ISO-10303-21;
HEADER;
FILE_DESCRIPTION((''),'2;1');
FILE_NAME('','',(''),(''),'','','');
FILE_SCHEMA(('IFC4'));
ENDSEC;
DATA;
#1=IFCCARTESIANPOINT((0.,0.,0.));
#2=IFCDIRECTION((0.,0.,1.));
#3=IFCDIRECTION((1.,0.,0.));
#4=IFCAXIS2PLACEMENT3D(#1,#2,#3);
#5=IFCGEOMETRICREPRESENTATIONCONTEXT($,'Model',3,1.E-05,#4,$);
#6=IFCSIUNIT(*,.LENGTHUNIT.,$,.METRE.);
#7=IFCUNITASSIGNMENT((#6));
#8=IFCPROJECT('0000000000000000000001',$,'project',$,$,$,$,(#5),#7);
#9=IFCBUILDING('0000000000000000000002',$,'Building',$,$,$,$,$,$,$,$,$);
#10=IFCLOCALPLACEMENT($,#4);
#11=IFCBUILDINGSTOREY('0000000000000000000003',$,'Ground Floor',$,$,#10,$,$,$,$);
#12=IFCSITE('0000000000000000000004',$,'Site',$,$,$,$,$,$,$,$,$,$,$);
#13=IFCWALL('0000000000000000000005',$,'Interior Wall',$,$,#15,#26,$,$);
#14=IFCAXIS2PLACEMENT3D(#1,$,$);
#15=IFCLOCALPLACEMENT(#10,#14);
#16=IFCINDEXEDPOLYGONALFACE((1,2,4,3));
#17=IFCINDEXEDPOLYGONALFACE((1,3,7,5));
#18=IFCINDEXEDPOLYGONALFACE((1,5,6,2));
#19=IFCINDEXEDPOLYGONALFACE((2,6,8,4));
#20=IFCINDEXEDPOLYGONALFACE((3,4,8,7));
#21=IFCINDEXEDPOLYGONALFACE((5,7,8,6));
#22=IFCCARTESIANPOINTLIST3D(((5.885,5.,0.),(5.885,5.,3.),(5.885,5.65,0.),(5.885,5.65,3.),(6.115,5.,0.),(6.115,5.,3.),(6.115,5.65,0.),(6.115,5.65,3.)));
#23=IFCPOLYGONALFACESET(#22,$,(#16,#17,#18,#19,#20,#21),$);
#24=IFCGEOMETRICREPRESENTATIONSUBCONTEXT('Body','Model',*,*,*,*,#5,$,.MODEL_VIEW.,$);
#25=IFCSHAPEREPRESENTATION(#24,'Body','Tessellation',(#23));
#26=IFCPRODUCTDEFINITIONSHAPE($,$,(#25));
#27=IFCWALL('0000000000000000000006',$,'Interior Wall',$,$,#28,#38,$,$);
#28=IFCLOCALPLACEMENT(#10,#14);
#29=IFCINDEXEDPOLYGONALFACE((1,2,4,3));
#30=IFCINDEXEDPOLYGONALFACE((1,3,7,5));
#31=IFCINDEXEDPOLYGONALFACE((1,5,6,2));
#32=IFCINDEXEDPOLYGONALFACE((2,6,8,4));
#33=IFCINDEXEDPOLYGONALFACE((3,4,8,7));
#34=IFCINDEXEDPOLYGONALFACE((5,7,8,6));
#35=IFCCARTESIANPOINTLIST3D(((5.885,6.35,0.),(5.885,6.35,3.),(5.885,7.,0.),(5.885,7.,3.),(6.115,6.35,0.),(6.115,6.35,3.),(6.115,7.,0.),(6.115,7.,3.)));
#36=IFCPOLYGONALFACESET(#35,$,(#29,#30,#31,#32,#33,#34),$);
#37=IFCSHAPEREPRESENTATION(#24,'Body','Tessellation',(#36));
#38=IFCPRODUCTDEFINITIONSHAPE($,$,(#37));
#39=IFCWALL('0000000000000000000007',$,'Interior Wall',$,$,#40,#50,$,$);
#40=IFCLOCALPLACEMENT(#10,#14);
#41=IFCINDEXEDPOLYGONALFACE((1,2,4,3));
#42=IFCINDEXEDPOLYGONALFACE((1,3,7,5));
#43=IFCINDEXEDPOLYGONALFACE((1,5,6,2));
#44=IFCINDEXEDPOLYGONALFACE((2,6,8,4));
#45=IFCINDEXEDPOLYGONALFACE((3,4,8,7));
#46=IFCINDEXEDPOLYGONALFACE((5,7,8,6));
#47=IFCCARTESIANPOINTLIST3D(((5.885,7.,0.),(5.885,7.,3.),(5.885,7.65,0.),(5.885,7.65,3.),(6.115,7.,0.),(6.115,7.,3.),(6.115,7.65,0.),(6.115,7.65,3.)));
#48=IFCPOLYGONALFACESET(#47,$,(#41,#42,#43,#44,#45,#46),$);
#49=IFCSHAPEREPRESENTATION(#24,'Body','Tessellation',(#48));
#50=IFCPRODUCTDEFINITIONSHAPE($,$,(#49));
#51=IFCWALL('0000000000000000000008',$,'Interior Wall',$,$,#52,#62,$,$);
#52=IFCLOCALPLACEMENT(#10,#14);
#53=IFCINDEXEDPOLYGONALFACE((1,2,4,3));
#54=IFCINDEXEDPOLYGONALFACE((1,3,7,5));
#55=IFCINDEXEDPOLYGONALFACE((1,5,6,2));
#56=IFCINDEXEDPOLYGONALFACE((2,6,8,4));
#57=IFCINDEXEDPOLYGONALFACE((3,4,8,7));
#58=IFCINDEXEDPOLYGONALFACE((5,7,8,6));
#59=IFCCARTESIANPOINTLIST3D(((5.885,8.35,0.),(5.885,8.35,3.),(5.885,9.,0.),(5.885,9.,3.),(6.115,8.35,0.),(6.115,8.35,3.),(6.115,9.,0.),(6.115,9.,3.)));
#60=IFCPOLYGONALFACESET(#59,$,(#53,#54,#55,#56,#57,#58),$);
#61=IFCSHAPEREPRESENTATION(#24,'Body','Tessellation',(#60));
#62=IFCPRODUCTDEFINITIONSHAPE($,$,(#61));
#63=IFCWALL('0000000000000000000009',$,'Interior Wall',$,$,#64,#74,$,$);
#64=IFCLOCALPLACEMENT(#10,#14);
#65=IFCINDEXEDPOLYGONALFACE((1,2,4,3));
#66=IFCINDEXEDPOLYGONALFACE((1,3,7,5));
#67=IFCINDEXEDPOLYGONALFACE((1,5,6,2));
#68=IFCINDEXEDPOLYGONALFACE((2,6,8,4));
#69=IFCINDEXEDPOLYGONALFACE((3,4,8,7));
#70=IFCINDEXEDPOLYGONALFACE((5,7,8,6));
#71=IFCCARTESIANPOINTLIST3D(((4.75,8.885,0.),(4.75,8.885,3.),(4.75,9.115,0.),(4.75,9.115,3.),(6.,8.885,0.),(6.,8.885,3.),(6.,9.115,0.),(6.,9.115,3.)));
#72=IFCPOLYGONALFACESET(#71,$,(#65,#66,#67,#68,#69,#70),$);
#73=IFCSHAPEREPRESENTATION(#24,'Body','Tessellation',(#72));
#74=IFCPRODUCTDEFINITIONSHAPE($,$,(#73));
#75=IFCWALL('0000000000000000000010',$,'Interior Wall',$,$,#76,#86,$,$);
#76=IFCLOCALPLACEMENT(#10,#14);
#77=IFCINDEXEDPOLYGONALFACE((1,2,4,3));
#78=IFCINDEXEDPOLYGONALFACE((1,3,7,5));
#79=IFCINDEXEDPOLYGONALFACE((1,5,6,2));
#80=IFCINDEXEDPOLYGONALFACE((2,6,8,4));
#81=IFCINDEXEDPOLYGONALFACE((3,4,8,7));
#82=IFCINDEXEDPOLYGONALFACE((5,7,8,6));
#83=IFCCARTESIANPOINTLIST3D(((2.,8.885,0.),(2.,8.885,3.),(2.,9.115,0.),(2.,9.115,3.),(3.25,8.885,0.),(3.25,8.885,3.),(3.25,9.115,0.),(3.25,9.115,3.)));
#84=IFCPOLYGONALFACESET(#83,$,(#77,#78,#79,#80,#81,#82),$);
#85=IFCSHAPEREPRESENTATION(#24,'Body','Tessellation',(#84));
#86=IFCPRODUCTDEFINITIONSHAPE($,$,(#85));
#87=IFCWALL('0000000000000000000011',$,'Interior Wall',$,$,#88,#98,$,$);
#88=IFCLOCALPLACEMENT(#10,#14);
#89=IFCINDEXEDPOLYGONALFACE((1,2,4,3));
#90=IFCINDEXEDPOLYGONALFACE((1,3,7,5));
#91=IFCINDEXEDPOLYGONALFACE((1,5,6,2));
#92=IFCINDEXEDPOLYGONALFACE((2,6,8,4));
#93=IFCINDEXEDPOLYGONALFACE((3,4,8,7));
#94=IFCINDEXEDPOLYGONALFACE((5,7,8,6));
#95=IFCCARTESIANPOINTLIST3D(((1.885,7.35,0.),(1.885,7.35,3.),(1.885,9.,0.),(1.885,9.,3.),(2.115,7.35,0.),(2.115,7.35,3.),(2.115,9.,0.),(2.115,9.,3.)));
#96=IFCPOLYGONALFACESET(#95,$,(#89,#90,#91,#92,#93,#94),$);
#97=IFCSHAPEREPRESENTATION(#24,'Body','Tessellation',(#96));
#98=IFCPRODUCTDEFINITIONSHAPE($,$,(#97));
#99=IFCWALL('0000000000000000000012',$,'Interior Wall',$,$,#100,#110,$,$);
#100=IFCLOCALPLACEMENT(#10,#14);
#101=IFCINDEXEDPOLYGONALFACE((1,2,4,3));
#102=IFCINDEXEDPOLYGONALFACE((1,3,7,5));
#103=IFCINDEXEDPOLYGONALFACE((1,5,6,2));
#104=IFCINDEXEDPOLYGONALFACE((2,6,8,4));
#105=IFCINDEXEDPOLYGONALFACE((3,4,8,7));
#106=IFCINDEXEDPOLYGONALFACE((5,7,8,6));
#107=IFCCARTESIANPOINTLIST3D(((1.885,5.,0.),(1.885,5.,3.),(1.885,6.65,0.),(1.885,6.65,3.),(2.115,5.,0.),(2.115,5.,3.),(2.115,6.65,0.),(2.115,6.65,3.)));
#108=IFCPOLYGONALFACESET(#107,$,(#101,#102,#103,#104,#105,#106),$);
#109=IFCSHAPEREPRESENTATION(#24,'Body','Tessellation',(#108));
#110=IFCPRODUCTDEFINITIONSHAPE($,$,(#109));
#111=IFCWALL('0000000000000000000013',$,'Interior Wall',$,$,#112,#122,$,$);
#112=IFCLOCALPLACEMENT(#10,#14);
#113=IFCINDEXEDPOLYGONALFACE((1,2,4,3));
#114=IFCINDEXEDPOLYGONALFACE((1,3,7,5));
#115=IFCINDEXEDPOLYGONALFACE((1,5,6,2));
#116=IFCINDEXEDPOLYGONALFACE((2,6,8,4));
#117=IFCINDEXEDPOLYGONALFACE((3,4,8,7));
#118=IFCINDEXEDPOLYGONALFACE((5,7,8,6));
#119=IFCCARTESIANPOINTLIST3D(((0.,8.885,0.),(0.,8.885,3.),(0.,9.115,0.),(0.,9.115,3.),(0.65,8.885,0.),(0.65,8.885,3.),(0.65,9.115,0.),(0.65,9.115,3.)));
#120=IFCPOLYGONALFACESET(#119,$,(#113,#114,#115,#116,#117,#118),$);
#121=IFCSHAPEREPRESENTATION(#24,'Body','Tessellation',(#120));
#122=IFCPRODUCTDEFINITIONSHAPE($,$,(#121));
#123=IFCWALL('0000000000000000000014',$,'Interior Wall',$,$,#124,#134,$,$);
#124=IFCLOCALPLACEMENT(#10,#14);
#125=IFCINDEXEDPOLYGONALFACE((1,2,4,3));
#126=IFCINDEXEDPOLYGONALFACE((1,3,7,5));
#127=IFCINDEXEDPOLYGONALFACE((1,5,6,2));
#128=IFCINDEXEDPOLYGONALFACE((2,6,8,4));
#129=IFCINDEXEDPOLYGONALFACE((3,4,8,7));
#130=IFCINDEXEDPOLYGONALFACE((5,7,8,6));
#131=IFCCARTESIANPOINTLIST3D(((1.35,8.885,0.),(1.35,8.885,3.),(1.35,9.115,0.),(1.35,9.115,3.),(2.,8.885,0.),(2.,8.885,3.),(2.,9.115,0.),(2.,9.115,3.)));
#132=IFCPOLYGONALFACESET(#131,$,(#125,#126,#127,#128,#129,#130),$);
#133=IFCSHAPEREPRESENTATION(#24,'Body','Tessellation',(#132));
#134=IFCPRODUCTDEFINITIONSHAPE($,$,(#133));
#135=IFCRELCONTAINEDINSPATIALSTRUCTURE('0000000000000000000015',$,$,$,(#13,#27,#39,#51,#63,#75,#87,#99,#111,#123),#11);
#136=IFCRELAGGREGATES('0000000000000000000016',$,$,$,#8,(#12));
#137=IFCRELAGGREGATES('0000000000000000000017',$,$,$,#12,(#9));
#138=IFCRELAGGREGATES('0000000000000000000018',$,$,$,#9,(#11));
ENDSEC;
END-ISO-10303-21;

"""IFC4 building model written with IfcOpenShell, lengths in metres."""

from ifc_helpers import new_model, si_unit, frame, origin_with_axes, place, context, subcontext, project, spatial, indexed_curve, outline, extrude, element, save


model = new_model("IFC4")

# Units and contexts
model_context = context("Model", 3, precision=1e-05, world=origin_with_axes())
body_context = subcontext(model_context, "Body", "Model", "MODEL_VIEW")
ifc_project = project(units=[si_unit("LENGTHUNIT", "METRE")], contexts=[model_context])

# Site, building, storey
site = spatial("IfcSite", under=ifc_project, Name="Site")
building = spatial("IfcBuilding", under=site, Name="Building")
storey_placement = place(None, origin_with_axes())
storey = spatial("IfcBuildingStorey", under=building, at=storey_placement, Name="Ground Floor")

# Walls
for number, where, z_axis, x_axis, name in (
    (1, (6.0, 5.0, 0.0), (0.0, 0.0, 1.0), (0.0, 1.0, 0.0), "Interior Wall"),
    (2, (6.0, 6.35, 0.0), (0.0, 0.0, 1.0), (0.0, 1.0, 0.0), "Interior Wall"),
    (3, (6.0, 7.0, 0.0), (0.0, 0.0, 1.0), (0.0, 1.0, 0.0), "Interior Wall"),
    (4, (6.0, 8.35, 0.0), (0.0, 0.0, 1.0), (0.0, 1.0, 0.0), "Interior Wall"),
):
    element("IfcWall", number, at=place(storey_placement, frame(where, z_axis=z_axis, x_axis=x_axis)), inside=storey, Name=name, context=body_context, shape_type="SweptSolid", body=[
        extrude(outline(indexed_curve([(0.0, 0.0), (0.0, 0.23), (0.65, 0.23), (0.65, 0.0), (0.0, 0.0)], self_intersect=False)), frame((0.0, -0.115, 0.0), z_axis=(0.0, 0.0, 1.0), x_axis=(1.0, 0.0, 0.0)), (0.0, 0.0, 1.0), 3.0),
    ])
for number, where, z_axis, x_axis, name in (
    (5, (6.0, 9.0, 0.0), (0.0, 0.0, 1.0), (-1.0, 0.0, 0.0), "Interior Wall"),
    (6, (3.25, 9.0, 0.0), (0.0, 0.0, 1.0), (-1.0, 0.0, 0.0), "Interior Wall"),
):
    element("IfcWall", number, at=place(storey_placement, frame(where, z_axis=z_axis, x_axis=x_axis)), inside=storey, Name=name, context=body_context, shape_type="SweptSolid", body=[
        extrude(outline(indexed_curve([(0.0, 0.0), (0.0, 0.23), (1.25, 0.23), (1.25, 0.0), (0.0, 0.0)], self_intersect=False)), frame((0.0, -0.115, 0.0), z_axis=(0.0, 0.0, 1.0), x_axis=(1.0, 0.0, 0.0)), (0.0, 0.0, 1.0), 3.0),
    ])
for number, where, z_axis, x_axis, name in (
    (7, (2.0, 9.0, 0.0), (0.0, 0.0, 1.0), (0.0, -1.0, 0.0), "Interior Wall"),
    (8, (2.0, 6.65, 0.0), (0.0, 0.0, 1.0), (0.0, -1.0, 0.0), "Interior Wall"),
):
    element("IfcWall", number, at=place(storey_placement, frame(where, z_axis=z_axis, x_axis=x_axis)), inside=storey, Name=name, context=body_context, shape_type="SweptSolid", body=[
        extrude(outline(indexed_curve([(0.0, 0.0), (0.0, 0.23), (1.65, 0.23), (1.65, 0.0), (0.0, 0.0)], self_intersect=False)), frame((0.0, -0.115, 0.0), z_axis=(0.0, 0.0, 1.0), x_axis=(1.0, 0.0, 0.0)), (0.0, 0.0, 1.0), 3.0),
    ])
wall_1_placement = place(storey_placement, frame((0.0, 9.0, 0.0), z_axis=(0.0, 0.0, 1.0), x_axis=(1.0, 0.0, 0.0)))
element("IfcWall", 9, at=wall_1_placement, inside=storey, Name="Interior Wall", context=body_context, shape_type="SweptSolid", body=[
    extrude(outline(indexed_curve([(0.0, 0.0), (0.0, 0.23), (0.65, 0.23), (0.65, 0.0), (0.0, 0.0)], self_intersect=False)), frame((0.0, -0.115, 0.0), z_axis=(0.0, 0.0, 1.0), x_axis=(1.0, 0.0, 0.0)), (0.0, 0.0, 1.0), 3.0),
])
wall_2_placement = place(storey_placement, frame((1.35, 9.0, 0.0), z_axis=(0.0, 0.0, 1.0), x_axis=(1.0, 0.0, 0.0)))
element("IfcWall", 10, at=wall_2_placement, inside=storey, Name="Interior Wall", context=body_context, shape_type="SweptSolid", body=[
    extrude(outline(indexed_curve([(0.0, 0.0), (0.0, 0.23), (0.65, 0.23), (0.65, 0.0), (0.0, 0.0)], self_intersect=False)), frame((0.0, -0.115, 0.0), z_axis=(0.0, 0.0, 1.0), x_axis=(1.0, 0.0, 0.0)), (0.0, 0.0, 1.0), 3.0),
])

save(model, "model.ifc")
